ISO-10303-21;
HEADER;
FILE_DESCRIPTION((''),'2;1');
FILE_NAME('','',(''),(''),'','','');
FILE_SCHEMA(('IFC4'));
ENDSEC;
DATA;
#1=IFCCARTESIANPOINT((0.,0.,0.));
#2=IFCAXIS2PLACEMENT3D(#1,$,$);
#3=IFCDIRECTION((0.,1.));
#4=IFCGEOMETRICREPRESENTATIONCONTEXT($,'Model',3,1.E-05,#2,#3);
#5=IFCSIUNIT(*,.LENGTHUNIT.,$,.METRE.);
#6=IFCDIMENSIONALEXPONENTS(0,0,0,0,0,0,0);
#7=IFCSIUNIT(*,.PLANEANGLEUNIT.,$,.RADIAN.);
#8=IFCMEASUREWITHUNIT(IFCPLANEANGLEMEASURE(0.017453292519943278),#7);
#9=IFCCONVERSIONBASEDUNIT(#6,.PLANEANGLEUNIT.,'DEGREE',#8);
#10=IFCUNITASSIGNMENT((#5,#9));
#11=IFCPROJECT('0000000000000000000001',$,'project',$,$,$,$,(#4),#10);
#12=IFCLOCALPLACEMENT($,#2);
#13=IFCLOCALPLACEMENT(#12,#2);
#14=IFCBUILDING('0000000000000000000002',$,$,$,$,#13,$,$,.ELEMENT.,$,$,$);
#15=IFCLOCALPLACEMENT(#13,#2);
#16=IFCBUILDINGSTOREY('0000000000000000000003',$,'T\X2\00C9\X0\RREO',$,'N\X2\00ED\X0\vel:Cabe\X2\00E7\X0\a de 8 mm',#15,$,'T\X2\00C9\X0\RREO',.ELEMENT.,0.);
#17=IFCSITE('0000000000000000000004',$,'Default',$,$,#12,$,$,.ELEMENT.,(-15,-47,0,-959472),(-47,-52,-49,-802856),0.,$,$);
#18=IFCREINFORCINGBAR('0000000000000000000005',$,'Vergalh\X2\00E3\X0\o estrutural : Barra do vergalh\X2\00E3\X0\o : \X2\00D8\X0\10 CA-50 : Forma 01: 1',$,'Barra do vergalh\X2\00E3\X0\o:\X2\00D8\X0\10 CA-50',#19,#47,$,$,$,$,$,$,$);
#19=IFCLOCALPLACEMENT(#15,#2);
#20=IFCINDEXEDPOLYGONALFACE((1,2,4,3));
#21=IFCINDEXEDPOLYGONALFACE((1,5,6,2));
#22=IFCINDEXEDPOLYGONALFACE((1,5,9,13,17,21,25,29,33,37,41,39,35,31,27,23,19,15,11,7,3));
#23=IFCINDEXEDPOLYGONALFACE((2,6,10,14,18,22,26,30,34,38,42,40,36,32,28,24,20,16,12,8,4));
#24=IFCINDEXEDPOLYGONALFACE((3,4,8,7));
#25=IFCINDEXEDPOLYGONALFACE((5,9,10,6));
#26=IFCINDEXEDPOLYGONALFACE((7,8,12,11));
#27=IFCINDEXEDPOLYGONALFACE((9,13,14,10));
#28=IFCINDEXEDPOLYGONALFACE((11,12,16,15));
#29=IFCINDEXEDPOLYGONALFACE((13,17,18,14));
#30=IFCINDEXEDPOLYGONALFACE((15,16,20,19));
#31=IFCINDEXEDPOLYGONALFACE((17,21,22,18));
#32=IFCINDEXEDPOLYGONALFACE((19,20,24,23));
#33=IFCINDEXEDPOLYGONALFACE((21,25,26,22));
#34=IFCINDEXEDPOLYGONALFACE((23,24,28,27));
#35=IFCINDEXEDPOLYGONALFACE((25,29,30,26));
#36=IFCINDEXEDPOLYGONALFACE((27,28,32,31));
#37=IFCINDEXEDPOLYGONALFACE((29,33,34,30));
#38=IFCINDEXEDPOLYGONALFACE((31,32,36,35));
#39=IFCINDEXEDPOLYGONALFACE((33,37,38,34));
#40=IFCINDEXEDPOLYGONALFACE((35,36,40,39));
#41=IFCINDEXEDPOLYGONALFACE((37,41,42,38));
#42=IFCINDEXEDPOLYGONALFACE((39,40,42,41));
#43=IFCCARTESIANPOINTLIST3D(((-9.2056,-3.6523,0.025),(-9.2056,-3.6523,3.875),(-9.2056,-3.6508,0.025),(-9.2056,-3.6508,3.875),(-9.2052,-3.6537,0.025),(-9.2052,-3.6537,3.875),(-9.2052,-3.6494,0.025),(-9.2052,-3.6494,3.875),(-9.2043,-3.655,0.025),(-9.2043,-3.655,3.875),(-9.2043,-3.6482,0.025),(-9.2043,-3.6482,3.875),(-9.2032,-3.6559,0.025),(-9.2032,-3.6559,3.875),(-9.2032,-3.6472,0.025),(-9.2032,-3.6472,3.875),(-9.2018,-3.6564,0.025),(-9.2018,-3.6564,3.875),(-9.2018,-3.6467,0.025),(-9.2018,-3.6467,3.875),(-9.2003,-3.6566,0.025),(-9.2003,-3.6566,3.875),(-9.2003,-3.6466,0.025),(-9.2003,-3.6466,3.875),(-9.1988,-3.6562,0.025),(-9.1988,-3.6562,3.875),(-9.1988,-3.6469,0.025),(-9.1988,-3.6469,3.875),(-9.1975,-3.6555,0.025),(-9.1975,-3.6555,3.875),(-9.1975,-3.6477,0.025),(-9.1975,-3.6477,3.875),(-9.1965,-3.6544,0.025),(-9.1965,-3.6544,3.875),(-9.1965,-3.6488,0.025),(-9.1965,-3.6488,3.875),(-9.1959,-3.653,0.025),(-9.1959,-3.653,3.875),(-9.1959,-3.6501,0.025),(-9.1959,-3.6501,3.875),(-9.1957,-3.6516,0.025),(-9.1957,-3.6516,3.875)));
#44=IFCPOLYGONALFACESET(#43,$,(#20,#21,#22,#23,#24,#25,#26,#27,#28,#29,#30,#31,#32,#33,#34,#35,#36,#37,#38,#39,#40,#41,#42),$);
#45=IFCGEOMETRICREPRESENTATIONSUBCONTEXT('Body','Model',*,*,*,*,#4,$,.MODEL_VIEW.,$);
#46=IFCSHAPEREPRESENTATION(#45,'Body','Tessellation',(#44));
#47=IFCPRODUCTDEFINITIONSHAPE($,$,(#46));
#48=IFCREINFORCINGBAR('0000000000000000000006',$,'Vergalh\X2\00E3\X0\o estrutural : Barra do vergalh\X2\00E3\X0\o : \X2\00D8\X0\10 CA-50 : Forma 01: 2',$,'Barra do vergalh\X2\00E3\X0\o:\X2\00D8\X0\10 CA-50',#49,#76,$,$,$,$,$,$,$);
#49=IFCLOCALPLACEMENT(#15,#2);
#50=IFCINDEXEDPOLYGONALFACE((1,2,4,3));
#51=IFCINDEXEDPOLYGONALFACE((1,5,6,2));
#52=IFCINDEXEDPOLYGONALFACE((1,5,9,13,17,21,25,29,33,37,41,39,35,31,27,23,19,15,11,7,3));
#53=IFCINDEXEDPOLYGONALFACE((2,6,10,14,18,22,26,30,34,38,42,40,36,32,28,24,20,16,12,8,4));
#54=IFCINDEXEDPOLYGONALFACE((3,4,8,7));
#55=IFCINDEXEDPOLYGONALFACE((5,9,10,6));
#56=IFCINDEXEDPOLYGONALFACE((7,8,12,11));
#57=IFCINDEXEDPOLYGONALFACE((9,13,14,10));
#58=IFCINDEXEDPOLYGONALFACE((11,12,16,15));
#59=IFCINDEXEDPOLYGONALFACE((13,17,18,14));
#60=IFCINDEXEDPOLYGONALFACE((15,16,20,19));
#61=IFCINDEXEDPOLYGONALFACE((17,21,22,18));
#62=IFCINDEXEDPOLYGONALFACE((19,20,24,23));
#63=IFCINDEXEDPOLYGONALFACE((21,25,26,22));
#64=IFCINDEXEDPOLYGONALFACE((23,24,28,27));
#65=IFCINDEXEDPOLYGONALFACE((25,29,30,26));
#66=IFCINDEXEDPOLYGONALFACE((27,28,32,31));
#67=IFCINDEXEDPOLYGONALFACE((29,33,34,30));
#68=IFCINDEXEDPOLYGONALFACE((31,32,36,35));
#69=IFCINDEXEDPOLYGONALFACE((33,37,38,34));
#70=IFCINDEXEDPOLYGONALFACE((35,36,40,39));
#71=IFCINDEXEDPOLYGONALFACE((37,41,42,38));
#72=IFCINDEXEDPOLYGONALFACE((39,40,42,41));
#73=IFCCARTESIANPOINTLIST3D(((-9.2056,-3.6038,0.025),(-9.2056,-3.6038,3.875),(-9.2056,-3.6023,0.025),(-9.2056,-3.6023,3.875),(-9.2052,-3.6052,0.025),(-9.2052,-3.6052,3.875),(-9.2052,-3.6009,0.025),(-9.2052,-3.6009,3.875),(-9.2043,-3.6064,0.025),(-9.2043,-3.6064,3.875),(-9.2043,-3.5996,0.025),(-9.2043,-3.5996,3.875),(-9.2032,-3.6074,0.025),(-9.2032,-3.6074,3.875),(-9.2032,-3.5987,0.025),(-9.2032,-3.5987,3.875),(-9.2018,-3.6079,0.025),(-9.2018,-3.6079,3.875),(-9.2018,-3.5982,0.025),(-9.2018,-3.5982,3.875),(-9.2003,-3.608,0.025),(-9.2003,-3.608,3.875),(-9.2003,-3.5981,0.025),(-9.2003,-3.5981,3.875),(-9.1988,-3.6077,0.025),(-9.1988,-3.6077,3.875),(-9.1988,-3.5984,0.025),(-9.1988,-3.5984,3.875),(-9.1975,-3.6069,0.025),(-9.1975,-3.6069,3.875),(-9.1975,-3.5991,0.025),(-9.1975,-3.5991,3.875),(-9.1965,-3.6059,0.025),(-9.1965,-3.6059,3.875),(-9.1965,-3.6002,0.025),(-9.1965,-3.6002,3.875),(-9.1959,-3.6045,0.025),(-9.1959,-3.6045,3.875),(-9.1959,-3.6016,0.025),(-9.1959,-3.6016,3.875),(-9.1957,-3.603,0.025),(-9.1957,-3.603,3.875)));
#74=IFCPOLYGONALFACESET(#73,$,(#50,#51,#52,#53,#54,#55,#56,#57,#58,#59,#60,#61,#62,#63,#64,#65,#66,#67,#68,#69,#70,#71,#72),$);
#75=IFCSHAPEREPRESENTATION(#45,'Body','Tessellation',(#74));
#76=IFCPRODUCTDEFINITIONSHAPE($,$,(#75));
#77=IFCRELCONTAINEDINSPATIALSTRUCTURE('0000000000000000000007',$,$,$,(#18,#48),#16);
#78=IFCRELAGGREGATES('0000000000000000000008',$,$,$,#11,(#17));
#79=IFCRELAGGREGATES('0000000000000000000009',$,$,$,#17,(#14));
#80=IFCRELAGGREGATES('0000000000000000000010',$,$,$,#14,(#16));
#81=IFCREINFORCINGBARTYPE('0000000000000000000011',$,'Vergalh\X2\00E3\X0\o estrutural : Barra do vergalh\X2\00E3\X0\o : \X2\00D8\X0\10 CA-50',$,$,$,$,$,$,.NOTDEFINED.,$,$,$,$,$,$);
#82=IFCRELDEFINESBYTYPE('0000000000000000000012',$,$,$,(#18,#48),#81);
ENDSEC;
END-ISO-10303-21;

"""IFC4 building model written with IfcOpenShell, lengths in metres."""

from ifc_helpers import new_model, entity, si_unit, converted_unit, direction, origin, place, context, subcontext, project, spatial, type_object, element, save


model = new_model("IFC4")

# Units and contexts
model_context = context("Model", 3, precision=1e-05, world=origin(), true_north=direction((0.0, 1.0)))
body_context = subcontext(model_context, "Body", "Model", "MODEL_VIEW")
ifc_project = project(units=[si_unit("LENGTHUNIT", "METRE"), converted_unit("PLANEANGLEUNIT", "DEGREE", entity("IfcPlaneAngleMeasure", 0.017453292519943278), si_unit("PLANEANGLEUNIT", "RADIAN"), dimensions=[0, 0, 0, 0, 0, 0, 0])], contexts=[model_context])

# Site, building, storey
site_placement = place(None, origin())
site = spatial("IfcSite", under=ifc_project, at=site_placement, Name="Default", CompositionType="ELEMENT", RefLatitude=(-15, -47, 0, -959472), RefLongitude=(-47, -52, -49, -802856), RefElevation=0.0)
building_placement = place(site_placement, origin())
building = spatial("IfcBuilding", under=site, at=building_placement, CompositionType="ELEMENT")
storey_placement = place(building_placement, origin())
storey = spatial("IfcBuildingStorey", under=building, at=storey_placement, Name="TÉRREO", ObjectType="Nível:Cabeça de 8 mm", LongName="TÉRREO", CompositionType="ELEMENT", Elevation=0.0)

# Reinforcing bars
reinforcing_bar_type_1 = type_object("IfcReinforcingBarType", Name="Vergalhão estrutural : Barra do vergalhão : Ø10 CA-50", PredefinedType="NOTDEFINED")
reinforcing_bar_1_placement = place(storey_placement, origin())
element("IfcReinforcingBar", 1, at=reinforcing_bar_1_placement, inside=storey, type_object=reinforcing_bar_type_1, Name="Vergalhão estrutural : Barra do vergalhão : Ø10 CA-50 : Forma 01: 1", ObjectType="Barra do vergalhão:Ø10 CA-50", context=body_context, shape_type="AdvancedSweptSolid", body=[
    entity("IfcSweptDiskSolid", entity("IfcIndexedPolyCurve", entity("IfcCartesianPointList3D", [[-9.2007, -3.6516, 0.025], [-9.2007, -3.6516, 3.875]]), None, False), 0.005, None, 0.0, 1.0),
])
reinforcing_bar_2_placement = place(storey_placement, origin())
element("IfcReinforcingBar", 2, at=reinforcing_bar_2_placement, inside=storey, type_object=reinforcing_bar_type_1, Name="Vergalhão estrutural : Barra do vergalhão : Ø10 CA-50 : Forma 01: 2", ObjectType="Barra do vergalhão:Ø10 CA-50", context=body_context, shape_type="AdvancedSweptSolid", body=[
    entity("IfcSweptDiskSolid", entity("IfcIndexedPolyCurve", entity("IfcCartesianPointList3D", [[-9.2007, -3.603, 0.025], [-9.2007, -3.603, 3.875]]), None, False), 0.005, None, 0.0, 1.0),
])

save(model, "model.ifc")
